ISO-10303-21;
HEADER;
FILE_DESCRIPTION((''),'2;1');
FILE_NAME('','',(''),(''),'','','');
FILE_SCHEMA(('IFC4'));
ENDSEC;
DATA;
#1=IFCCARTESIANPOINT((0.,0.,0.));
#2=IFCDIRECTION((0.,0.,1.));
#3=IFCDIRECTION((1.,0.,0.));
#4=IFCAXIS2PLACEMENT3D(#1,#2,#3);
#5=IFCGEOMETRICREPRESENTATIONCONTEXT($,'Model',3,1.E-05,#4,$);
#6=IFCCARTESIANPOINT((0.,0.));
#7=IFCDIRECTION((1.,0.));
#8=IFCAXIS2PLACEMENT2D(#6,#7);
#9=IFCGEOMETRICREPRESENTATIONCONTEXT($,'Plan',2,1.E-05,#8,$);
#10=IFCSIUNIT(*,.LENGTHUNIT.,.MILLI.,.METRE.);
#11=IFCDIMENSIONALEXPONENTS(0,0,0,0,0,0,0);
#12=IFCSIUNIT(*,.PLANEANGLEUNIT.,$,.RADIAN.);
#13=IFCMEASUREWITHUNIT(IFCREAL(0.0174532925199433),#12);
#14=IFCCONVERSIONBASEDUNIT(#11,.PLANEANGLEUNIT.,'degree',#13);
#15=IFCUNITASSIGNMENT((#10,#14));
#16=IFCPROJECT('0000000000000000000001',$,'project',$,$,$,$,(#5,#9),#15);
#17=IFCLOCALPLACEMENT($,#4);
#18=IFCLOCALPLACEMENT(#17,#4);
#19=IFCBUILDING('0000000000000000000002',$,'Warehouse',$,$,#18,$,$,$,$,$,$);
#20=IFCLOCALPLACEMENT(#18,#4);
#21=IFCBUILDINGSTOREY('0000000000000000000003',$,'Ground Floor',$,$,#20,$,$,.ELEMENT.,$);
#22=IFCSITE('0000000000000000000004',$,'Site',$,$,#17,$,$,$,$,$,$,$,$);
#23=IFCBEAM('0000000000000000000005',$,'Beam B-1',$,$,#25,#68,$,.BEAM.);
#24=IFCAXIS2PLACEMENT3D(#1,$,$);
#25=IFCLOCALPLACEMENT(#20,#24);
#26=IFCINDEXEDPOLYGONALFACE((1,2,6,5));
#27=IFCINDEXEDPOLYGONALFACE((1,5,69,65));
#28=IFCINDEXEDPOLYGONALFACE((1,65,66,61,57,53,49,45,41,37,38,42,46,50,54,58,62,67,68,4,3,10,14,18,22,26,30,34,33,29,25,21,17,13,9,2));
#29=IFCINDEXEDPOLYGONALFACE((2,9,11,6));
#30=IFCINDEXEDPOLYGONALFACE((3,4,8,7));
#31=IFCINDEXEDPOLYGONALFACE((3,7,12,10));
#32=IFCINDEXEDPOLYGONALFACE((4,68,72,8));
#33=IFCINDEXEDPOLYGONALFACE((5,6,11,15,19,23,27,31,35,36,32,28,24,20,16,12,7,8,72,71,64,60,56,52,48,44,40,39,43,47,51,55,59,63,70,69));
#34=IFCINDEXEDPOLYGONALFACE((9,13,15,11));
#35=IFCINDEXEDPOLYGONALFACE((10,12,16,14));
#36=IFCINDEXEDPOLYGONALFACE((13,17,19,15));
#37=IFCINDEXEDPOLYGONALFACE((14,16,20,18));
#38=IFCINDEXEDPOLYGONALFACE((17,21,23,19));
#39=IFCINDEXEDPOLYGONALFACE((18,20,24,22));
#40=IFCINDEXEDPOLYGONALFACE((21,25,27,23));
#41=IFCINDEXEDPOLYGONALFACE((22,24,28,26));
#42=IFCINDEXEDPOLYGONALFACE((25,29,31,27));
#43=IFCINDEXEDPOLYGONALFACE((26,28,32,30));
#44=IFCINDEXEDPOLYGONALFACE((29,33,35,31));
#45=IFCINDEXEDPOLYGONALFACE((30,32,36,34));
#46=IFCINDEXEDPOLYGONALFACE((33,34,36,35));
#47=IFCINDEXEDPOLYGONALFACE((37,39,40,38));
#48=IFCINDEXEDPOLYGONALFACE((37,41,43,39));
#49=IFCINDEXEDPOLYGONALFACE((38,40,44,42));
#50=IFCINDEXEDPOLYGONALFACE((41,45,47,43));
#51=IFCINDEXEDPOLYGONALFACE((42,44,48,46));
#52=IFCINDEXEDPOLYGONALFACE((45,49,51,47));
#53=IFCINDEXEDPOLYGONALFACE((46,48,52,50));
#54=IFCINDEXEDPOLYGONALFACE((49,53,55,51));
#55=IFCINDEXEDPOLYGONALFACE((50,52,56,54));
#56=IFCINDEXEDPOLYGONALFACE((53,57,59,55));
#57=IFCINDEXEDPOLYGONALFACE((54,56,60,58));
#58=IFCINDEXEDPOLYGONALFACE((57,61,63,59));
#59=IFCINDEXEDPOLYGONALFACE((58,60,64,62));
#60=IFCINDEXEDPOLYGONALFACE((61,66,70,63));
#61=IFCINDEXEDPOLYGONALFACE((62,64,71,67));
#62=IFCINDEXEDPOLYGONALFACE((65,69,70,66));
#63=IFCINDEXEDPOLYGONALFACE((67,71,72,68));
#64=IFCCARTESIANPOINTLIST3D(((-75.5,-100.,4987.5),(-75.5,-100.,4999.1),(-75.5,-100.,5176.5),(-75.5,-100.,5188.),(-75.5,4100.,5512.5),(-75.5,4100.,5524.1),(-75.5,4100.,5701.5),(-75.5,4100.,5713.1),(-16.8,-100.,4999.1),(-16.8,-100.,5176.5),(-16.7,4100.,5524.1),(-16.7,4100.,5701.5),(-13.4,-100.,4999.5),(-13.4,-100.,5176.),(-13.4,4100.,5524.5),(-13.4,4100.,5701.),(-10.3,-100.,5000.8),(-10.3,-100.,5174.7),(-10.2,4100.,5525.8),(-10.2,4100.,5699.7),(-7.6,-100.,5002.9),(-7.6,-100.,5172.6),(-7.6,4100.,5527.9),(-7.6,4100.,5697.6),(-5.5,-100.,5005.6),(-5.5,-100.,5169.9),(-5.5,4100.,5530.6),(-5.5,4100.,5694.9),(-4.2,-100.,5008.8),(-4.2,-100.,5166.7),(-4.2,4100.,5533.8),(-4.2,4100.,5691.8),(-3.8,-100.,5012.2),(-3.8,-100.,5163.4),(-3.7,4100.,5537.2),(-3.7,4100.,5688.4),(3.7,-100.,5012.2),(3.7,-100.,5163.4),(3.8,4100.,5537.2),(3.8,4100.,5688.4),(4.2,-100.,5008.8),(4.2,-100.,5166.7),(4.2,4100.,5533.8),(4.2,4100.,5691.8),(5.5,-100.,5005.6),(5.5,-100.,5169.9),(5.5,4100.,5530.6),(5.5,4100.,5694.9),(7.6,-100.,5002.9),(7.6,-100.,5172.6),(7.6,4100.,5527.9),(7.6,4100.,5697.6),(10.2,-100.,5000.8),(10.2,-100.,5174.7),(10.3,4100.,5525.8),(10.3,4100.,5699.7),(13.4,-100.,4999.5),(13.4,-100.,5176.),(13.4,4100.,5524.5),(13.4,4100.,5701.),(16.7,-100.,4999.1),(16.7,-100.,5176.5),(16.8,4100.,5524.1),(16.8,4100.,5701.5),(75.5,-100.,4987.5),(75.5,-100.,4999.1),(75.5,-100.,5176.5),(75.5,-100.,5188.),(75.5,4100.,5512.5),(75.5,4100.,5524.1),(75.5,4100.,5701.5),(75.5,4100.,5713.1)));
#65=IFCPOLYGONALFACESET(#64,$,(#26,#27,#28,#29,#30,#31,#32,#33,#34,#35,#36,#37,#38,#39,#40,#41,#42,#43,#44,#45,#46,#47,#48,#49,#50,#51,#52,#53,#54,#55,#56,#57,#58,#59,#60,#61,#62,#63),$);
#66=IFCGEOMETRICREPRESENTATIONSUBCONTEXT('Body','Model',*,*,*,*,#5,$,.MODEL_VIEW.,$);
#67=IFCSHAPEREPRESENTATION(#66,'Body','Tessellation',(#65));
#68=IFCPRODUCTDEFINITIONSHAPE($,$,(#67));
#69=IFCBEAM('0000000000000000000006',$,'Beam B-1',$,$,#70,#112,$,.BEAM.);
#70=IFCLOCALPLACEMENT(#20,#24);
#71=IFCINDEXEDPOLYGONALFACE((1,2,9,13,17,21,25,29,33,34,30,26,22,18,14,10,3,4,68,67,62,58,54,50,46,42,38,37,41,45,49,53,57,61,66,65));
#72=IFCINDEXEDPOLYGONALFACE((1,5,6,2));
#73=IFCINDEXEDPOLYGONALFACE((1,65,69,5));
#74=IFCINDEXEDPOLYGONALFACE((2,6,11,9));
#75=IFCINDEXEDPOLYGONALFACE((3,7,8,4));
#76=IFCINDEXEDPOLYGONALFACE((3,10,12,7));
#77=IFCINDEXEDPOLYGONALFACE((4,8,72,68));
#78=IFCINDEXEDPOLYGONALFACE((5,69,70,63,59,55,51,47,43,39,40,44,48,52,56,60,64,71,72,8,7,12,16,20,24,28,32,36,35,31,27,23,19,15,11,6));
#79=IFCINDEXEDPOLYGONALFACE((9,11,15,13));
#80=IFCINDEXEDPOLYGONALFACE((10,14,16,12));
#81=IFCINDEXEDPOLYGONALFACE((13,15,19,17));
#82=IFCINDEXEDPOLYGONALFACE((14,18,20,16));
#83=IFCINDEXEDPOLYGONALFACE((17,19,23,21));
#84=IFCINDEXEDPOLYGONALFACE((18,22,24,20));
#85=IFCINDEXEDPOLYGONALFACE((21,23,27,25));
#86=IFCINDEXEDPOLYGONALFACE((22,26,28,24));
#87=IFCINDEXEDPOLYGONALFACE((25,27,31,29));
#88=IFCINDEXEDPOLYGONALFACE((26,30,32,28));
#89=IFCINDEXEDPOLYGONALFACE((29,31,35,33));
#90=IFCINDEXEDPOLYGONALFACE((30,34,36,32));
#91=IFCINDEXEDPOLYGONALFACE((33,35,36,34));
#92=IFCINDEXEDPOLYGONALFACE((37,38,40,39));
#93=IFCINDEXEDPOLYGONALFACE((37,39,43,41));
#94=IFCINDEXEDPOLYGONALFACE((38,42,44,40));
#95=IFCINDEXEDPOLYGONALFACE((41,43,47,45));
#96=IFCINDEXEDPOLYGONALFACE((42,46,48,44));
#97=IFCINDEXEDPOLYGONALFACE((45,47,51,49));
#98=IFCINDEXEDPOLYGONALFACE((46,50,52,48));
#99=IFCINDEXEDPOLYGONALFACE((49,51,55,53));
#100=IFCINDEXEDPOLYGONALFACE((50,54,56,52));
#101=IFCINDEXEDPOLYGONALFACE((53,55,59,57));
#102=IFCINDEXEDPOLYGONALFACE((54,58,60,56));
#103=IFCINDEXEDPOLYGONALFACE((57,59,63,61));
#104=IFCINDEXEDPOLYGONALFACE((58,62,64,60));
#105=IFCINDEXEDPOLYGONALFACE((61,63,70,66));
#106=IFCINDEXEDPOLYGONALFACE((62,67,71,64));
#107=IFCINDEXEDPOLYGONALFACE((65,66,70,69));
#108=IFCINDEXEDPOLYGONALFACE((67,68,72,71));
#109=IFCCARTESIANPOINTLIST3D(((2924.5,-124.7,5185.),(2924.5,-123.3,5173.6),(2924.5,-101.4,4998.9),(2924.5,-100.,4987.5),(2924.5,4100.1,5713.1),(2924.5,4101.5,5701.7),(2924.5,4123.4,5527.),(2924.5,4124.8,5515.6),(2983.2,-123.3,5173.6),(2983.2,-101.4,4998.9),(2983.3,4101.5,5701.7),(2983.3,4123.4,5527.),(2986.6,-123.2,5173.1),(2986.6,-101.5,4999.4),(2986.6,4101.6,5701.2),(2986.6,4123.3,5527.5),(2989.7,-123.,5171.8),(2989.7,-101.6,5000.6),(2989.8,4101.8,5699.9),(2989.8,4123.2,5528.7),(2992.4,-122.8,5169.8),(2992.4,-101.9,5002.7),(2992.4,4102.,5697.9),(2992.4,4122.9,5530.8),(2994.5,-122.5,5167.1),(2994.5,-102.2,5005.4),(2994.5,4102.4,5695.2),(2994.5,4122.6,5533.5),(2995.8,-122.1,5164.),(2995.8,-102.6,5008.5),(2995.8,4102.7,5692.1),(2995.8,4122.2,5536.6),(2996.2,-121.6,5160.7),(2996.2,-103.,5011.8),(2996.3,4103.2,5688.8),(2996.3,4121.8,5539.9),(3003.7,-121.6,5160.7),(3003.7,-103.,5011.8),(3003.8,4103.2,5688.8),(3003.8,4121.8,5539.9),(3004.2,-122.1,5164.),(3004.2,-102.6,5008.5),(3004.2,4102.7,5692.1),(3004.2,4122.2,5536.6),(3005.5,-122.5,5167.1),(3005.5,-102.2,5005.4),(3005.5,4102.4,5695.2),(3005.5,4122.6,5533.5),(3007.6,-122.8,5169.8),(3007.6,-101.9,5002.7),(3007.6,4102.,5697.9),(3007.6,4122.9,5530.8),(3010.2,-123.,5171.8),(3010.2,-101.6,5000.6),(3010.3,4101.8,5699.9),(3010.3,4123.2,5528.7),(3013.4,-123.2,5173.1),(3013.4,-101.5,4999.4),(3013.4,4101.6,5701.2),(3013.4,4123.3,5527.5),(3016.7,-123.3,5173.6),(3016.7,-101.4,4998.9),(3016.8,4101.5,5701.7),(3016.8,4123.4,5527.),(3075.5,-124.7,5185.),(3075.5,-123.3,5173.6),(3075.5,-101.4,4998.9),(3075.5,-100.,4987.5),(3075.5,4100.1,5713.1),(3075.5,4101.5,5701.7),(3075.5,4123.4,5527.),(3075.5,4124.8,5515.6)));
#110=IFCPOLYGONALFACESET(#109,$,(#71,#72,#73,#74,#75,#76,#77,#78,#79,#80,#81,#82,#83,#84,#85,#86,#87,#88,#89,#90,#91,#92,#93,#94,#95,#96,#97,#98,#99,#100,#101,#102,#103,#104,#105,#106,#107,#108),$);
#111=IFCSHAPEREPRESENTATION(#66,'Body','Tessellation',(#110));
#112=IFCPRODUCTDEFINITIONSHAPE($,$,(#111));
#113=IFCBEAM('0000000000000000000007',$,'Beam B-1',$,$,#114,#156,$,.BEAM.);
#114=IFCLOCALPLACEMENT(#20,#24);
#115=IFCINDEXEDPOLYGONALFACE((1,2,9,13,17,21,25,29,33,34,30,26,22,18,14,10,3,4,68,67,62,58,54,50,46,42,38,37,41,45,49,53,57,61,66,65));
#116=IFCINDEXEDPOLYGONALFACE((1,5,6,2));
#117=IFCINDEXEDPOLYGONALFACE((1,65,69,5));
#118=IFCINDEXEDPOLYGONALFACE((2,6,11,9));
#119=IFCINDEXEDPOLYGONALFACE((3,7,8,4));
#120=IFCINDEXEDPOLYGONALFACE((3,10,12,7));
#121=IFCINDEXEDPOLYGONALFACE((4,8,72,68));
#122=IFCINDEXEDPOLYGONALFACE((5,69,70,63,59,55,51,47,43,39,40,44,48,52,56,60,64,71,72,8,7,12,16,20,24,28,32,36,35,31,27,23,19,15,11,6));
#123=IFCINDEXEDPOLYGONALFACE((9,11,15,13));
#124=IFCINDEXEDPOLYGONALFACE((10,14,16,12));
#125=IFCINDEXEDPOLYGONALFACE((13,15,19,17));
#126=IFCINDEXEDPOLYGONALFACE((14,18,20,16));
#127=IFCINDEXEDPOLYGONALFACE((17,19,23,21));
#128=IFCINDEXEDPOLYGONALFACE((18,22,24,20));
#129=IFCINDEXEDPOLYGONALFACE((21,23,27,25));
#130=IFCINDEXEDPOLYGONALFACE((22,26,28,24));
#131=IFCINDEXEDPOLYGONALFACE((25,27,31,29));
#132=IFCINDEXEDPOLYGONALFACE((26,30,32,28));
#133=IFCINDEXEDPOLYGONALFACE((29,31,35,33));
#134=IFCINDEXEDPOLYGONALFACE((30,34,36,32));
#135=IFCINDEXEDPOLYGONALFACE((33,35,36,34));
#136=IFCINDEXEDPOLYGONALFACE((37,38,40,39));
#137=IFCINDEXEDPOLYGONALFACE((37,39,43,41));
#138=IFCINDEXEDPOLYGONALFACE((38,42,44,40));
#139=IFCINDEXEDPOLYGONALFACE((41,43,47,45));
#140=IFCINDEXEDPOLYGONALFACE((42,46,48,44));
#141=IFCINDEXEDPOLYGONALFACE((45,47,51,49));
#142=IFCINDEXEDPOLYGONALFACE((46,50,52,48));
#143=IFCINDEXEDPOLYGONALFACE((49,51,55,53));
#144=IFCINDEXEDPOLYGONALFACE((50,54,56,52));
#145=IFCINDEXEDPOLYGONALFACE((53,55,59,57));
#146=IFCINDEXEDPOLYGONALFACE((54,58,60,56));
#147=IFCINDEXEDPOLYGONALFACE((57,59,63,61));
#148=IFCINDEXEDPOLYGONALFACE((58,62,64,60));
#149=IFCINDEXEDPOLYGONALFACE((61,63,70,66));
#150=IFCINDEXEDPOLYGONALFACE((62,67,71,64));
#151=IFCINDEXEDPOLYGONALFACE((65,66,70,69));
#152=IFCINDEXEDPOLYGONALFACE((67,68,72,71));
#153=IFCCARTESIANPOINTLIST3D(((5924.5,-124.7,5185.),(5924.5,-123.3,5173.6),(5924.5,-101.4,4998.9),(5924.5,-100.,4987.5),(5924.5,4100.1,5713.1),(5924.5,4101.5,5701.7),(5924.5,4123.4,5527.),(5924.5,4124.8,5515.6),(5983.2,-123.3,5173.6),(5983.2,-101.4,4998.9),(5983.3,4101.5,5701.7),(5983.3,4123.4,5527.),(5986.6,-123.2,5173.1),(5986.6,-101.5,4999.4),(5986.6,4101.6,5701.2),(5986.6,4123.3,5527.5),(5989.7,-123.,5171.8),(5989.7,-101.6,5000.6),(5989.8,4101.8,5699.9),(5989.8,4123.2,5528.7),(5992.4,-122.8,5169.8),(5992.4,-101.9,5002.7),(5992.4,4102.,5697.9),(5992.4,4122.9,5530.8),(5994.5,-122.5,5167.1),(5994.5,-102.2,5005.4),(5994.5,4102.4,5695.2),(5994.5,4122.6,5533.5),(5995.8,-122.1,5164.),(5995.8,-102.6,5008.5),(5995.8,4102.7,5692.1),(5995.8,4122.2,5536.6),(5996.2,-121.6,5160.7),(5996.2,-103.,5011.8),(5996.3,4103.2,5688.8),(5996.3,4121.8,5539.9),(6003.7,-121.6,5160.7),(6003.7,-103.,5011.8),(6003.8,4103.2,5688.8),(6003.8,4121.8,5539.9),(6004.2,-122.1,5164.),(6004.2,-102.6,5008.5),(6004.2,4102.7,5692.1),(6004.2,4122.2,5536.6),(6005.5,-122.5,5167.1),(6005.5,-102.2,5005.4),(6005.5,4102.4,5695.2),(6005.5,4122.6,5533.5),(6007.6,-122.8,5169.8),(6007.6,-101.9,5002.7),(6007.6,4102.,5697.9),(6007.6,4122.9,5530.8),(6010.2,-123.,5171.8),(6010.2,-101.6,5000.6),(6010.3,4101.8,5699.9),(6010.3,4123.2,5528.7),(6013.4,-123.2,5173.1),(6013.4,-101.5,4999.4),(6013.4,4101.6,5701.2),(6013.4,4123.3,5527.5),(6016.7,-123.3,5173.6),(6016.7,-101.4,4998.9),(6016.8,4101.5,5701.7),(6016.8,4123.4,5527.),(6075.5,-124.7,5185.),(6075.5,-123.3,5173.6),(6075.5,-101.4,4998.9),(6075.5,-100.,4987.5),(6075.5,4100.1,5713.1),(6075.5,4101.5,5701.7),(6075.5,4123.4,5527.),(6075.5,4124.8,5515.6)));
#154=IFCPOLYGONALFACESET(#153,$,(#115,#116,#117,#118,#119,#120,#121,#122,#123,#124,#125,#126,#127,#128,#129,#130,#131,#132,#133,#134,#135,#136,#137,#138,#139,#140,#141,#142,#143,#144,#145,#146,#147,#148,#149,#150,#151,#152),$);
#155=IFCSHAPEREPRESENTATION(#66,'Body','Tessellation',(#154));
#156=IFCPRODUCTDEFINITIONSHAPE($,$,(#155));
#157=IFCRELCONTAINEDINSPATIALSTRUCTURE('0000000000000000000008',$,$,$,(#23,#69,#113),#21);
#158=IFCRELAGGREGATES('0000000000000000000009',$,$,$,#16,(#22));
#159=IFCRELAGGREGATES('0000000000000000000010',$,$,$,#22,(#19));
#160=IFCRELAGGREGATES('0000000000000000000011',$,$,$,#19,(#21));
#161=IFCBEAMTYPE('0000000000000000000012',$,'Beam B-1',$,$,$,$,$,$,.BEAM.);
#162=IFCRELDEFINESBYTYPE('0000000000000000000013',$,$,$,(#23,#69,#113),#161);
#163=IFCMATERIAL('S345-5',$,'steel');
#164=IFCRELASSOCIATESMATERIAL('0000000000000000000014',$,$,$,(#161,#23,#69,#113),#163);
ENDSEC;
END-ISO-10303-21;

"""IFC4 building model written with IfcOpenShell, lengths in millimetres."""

from ifc_helpers import new_model, entity, si_unit, converted_unit, frame, origin_with_axes, origin_2d_with_axis, place, context, subcontext, project, spatial, i_section, extrude, clip, halfspace, material, material_profile, profile_set, profile_usage, type_object, element, save


model = new_model("IFC4")

# Units and contexts
model_context = context("Model", 3, precision=1e-05, world=origin_with_axes())
plan_context = context("Plan", 2, precision=1e-05, world=origin_2d_with_axis())
body_context = subcontext(model_context, "Body", "Model", "MODEL_VIEW")
ifc_project = project(units=[si_unit("LENGTHUNIT", "METRE", prefix="MILLI"), converted_unit("PLANEANGLEUNIT", "degree", entity("IfcReal", 0.0174532925199433), si_unit("PLANEANGLEUNIT", "RADIAN"), dimensions=[0, 0, 0, 0, 0, 0, 0])], contexts=[model_context, plan_context])

# Site, building, storey
site_placement = place(None, origin_with_axes())
site = spatial("IfcSite", under=ifc_project, at=site_placement, Name="Site")
building_placement = place(site_placement, origin_with_axes())
building = spatial("IfcBuilding", under=site, at=building_placement, Name="Warehouse")
storey_placement = place(building_placement, origin_with_axes())
storey = spatial("IfcBuildingStorey", under=building, at=storey_placement, Name="Ground Floor", CompositionType="ELEMENT")

# Shared definitions
ifc_material_1 = material(Name="S345-5", Category="steel")

# Beams
ifc_material_profile_1 = material_profile(ifc_material_1, i_section(OverallWidth=151.0, OverallDepth=199.0, WebThickness=7.5, FlangeThickness=11.5, FilletRadius=13.0, FlangeEdgeRadius=0.0, FlangeSlope=0.0))
ifc_profile_set_1 = profile_set([ifc_material_profile_1], Name="I20H2_S345-5")
ifc_profile_usage_1 = profile_usage(ifc_profile_set_1, cardinal=2)
beam_type_1 = type_object("IfcBeamType", Name="Beam B-1", PredefinedType="BEAM", material=ifc_profile_set_1)
beam_1_placement = place(storey_placement, frame((0.0, -298.5, 4962.7), z_axis=(0.0, 0.992278, 0.124035), x_axis=(-1.0, 0.0, 0.0)))
element("IfcBeam", 1, at=beam_1_placement, inside=storey, type_object=beam_type_1, material=ifc_profile_usage_1, Name="Beam B-1", PredefinedType="BEAM", context=body_context, shape_type="Clipping", body=[
    clip(clip(extrude(i_section(OverallWidth=151.0, OverallDepth=199.0, WebThickness=7.5, FlangeThickness=11.5, FilletRadius=13.0, FlangeEdgeRadius=0.0, FlangeSlope=0.0), frame((0.0, 99.5, 0.0), z_axis=(0.0, 0.0, 1.0), x_axis=(1.0, 0.0, 0.0)), (0.0, 0.0, 1.0), 4632.7), halfspace(frame((0.0, -5469.9, 3748.9), z_axis=(0.0, -0.124035, 0.992278), x_axis=(0.0, 0.992278, 0.124035)), False)), halfspace(frame((0.0, -4949.0, -418.6), z_axis=(0.0, 0.124035, -0.992278), x_axis=(0.0, 0.992278, 0.124035)), False)),
])
ifc_profile_usage_2 = profile_usage(ifc_profile_set_1, cardinal=2)
beam_2_placement = place(storey_placement, frame((3000.0, -100.0, 4987.5), z_axis=(0.0, 0.992278, 0.124035), x_axis=(-1.0, 0.0, 0.0)))
element("IfcBeam", 2, at=beam_2_placement, inside=storey, type_object=beam_type_1, material=ifc_profile_usage_2, Name="Beam B-1", PredefinedType="BEAM", context=body_context, shape_type="SweptSolid", body=[
    extrude(i_section(OverallWidth=151.0, OverallDepth=199.0, WebThickness=7.5, FlangeThickness=11.5, FilletRadius=13.0, FlangeEdgeRadius=0.0, FlangeSlope=0.0), frame((0.0, 99.5, 0.0), z_axis=(0.0, 0.0, 1.0), x_axis=(1.0, 0.0, 0.0)), (0.0, 0.0, 1.0), 4257.7),
])
ifc_profile_usage_3 = profile_usage(ifc_profile_set_1, cardinal=2)
beam_3_placement = place(storey_placement, frame((6000.0, -100.0, 4987.5), z_axis=(0.0, 0.992278, 0.124035), x_axis=(-1.0, 0.0, 0.0)))
element("IfcBeam", 3, at=beam_3_placement, inside=storey, type_object=beam_type_1, material=ifc_profile_usage_3, Name="Beam B-1", PredefinedType="BEAM", context=body_context, shape_type="SweptSolid", body=[
    extrude(i_section(OverallWidth=151.0, OverallDepth=199.0, WebThickness=7.5, FlangeThickness=11.5, FilletRadius=13.0, FlangeEdgeRadius=0.0, FlangeSlope=0.0), frame((0.0, 99.5, 0.0), z_axis=(0.0, 0.0, 1.0), x_axis=(1.0, 0.0, 0.0)), (0.0, 0.0, 1.0), 4257.7),
])

save(model, "model.ifc")
